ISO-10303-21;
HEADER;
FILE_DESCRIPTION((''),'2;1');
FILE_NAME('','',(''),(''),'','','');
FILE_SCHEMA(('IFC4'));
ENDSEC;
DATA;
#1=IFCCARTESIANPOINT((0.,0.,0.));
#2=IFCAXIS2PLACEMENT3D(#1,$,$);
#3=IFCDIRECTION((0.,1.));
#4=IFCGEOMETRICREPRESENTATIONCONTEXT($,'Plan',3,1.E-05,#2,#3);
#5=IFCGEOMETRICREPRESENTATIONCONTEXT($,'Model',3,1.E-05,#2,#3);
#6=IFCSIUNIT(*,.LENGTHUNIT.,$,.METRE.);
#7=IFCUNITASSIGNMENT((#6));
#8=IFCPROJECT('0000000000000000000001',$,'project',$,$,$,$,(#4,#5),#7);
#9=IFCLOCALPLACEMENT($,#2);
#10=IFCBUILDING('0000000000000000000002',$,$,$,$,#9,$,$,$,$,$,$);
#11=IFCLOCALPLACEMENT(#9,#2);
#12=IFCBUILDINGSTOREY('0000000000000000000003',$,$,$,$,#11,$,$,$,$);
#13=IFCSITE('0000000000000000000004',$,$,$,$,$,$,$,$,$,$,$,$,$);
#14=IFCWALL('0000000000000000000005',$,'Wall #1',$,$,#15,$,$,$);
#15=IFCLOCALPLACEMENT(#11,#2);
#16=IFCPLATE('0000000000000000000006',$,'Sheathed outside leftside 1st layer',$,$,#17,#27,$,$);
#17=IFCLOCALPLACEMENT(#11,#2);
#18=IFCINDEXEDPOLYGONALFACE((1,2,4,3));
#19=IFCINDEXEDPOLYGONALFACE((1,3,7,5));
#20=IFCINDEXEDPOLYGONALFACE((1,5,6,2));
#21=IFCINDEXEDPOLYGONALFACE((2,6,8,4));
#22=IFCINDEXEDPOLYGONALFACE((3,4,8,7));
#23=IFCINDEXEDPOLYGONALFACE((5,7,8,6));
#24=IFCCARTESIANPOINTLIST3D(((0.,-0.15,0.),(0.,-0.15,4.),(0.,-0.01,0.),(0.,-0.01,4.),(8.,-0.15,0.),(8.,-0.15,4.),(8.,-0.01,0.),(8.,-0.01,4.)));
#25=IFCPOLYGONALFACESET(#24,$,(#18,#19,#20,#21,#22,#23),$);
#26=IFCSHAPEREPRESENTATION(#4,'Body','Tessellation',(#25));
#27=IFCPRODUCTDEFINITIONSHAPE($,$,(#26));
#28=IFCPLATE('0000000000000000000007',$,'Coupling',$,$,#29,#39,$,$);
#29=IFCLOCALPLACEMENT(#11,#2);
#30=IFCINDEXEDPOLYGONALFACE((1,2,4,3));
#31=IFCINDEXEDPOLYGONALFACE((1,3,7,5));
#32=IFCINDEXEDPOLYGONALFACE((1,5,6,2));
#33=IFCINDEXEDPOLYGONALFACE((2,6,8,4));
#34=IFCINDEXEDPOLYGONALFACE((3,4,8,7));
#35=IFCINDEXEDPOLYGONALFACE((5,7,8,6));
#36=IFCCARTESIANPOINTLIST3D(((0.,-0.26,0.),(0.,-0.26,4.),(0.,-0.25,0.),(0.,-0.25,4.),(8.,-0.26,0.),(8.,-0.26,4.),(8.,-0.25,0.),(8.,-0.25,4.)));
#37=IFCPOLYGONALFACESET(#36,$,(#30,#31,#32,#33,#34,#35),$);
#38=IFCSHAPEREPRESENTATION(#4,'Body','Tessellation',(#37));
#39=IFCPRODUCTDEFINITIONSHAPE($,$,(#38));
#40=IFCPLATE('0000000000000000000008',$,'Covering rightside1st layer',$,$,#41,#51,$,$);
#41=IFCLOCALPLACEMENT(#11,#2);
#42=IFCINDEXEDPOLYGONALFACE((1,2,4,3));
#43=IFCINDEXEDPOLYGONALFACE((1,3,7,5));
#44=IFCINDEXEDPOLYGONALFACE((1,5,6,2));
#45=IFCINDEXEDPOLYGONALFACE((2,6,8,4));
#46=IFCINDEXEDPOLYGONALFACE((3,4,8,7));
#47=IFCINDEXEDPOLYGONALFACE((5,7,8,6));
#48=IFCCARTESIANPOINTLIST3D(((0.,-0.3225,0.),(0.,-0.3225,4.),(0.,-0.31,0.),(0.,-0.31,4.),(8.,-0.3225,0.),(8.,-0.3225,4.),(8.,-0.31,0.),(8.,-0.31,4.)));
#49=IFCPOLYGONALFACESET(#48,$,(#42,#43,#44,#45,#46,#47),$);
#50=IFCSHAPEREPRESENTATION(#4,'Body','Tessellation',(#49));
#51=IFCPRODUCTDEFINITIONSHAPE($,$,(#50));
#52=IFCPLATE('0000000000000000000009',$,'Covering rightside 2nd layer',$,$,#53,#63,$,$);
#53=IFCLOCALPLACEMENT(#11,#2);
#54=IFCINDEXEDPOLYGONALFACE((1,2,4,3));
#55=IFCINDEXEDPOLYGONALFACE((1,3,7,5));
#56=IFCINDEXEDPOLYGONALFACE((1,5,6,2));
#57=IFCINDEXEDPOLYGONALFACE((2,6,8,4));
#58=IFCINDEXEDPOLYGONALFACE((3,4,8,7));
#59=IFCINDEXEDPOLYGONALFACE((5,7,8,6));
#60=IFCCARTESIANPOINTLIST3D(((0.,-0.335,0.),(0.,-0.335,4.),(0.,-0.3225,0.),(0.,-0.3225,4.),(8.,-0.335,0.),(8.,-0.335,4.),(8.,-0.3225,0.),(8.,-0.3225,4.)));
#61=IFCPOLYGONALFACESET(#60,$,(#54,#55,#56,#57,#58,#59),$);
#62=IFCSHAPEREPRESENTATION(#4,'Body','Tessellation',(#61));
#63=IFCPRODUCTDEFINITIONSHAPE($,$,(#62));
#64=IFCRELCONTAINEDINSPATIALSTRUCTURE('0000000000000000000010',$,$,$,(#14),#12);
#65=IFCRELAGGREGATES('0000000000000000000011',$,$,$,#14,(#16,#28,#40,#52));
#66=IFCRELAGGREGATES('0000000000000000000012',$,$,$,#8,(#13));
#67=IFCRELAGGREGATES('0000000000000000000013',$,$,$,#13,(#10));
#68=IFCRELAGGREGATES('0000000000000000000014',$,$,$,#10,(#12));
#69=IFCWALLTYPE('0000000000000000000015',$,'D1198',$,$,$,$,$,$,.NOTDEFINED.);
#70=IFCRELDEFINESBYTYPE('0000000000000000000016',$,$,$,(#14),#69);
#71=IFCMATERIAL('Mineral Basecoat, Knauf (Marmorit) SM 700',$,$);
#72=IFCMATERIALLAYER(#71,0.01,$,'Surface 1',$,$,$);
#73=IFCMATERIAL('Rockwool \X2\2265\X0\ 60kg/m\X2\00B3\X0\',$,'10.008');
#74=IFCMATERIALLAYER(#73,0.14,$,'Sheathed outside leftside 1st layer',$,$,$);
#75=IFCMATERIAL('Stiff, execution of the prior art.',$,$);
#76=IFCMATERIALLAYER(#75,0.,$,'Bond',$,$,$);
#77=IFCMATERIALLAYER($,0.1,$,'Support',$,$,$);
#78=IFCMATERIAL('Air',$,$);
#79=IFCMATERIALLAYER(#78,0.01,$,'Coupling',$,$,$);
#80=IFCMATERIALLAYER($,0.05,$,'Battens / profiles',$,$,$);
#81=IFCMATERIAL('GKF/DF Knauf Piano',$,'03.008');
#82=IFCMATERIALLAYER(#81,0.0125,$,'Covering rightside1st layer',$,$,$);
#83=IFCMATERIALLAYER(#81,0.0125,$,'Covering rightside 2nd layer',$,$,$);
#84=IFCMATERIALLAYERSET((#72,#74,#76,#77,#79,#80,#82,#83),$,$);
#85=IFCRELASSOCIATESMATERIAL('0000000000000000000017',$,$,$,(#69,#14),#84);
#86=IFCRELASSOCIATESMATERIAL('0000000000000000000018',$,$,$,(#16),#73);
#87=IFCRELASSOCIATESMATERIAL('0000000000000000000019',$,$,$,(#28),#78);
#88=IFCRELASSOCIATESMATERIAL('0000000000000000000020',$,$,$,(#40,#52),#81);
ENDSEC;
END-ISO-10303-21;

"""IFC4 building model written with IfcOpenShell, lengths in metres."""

from ifc_helpers import new_model, si_unit, direction, frame, frame_2d, origin, place, context, project, spatial, rectangle, extrude, material, layer, layer_set, type_object, element, aggregate, save


model = new_model("IFC4")

# Units and contexts
plan_context = context("Plan", 3, precision=1e-05, world=origin(), true_north=direction((0.0, 1.0)))
model_context = context("Model", 3, precision=1e-05, world=origin(), true_north=direction((0.0, 1.0)))
ifc_project = project(units=[si_unit("LENGTHUNIT", "METRE")], contexts=[plan_context, model_context])

# Site, building, storey
site = spatial("IfcSite", under=ifc_project)
building_placement = place(None, origin())
building = spatial("IfcBuilding", under=site, at=building_placement)
storey_placement = place(building_placement, origin())
storey = spatial("IfcBuildingStorey", under=building, at=storey_placement)

# Wall, plates
ifc_material_1 = material(Name="Mineral Basecoat, Knauf (Marmorit) SM 700")
ifc_layer_1 = layer(ifc_material_1, 0.01, Name="Surface 1")
ifc_material_2 = material(Name="Rockwool ≥ 60kg/m³", Category="10.008")
ifc_layer_2 = layer(ifc_material_2, 0.14, Name="Sheathed outside leftside 1st layer")
ifc_material_3 = material(Name="Stiff, execution of the prior art.")
ifc_layer_3 = layer(ifc_material_3, 0.0, Name="Bond")
ifc_layer_4 = layer(None, 0.1, Name="Support")
ifc_material_4 = material(Name="Air")
ifc_layer_5 = layer(ifc_material_4, 0.01, Name="Coupling")
ifc_layer_6 = layer(None, 0.05, Name="Battens / profiles")
ifc_material_5 = material(Name="GKF/DF Knauf Piano", Category="03.008")
ifc_layer_7 = layer(ifc_material_5, 0.0125, Name="Covering rightside1st layer")
ifc_layer_8 = layer(ifc_material_5, 0.0125, Name="Covering rightside 2nd layer")
ifc_layer_set = layer_set([ifc_layer_1, ifc_layer_2, ifc_layer_3, ifc_layer_4, ifc_layer_5, ifc_layer_6, ifc_layer_7, ifc_layer_8])
wall_type = type_object("IfcWallType", Name="D1198", PredefinedType="NOTDEFINED", material=ifc_layer_set)
wall_placement = place(None, frame((0.0, 0.0, 0.0), z_axis=(0.0, -1.0, 0.0), x_axis=(1.0, 0.0, 0.0)))
wall = element("IfcWall", 1, at=wall_placement, inside=storey, type_object=wall_type, material=ifc_layer_set, Name="Wall #1")
plate_1_placement = place(wall_placement, origin())
plate_1 = element("IfcPlate", 2, at=plate_1_placement, material=ifc_material_2, Name="Sheathed outside leftside 1st layer", context=plan_context, shape_type="SweptSolid", body=[
    extrude(rectangle(XDim=8.0, YDim=4.0, at=frame_2d((4.0, 2.0), x_axis=(1.0, 0.0))), frame((0.0, 0.0, 0.01), z_axis=(0.0, 0.0, 1.0), x_axis=(1.0, 0.0, 0.0)), (0.0, 0.0, 1.0), 0.14),
])
plate_2_placement = place(wall_placement, origin())
plate_2 = element("IfcPlate", 3, at=plate_2_placement, material=ifc_material_4, Name="Coupling", context=plan_context, shape_type="SweptSolid", body=[
    extrude(rectangle(XDim=8.0, YDim=4.0, at=frame_2d((4.0, 2.0), x_axis=(1.0, 0.0))), frame((0.0, 0.0, 0.25), z_axis=(0.0, 0.0, 1.0), x_axis=(1.0, 0.0, 0.0)), (0.0, 0.0, 1.0), 0.01),
])
plate_3_placement = place(wall_placement, origin())
plate_3 = element("IfcPlate", 4, at=plate_3_placement, material=ifc_material_5, Name="Covering rightside1st layer", context=plan_context, shape_type="SweptSolid", body=[
    extrude(rectangle(XDim=8.0, YDim=4.0, at=frame_2d((4.0, 2.0), x_axis=(1.0, 0.0))), frame((0.0, 0.0, 0.31), z_axis=(0.0, 0.0, 1.0), x_axis=(1.0, 0.0, 0.0)), (0.0, 0.0, 1.0), 0.0125),
])
plate_4_placement = place(wall_placement, origin())
plate_4 = element("IfcPlate", 5, at=plate_4_placement, material=ifc_material_5, Name="Covering rightside 2nd layer", context=plan_context, shape_type="SweptSolid", body=[
    extrude(rectangle(XDim=8.0, YDim=4.0, at=frame_2d((4.0, 2.0), x_axis=(1.0, 0.0))), frame((0.0, 0.0, 0.3225), z_axis=(0.0, 0.0, 1.0), x_axis=(1.0, 0.0, 0.0)), (0.0, 0.0, 1.0), 0.0125),
])
aggregate(wall, [plate_1, plate_2, plate_3, plate_4])

save(model, "model.ifc")
